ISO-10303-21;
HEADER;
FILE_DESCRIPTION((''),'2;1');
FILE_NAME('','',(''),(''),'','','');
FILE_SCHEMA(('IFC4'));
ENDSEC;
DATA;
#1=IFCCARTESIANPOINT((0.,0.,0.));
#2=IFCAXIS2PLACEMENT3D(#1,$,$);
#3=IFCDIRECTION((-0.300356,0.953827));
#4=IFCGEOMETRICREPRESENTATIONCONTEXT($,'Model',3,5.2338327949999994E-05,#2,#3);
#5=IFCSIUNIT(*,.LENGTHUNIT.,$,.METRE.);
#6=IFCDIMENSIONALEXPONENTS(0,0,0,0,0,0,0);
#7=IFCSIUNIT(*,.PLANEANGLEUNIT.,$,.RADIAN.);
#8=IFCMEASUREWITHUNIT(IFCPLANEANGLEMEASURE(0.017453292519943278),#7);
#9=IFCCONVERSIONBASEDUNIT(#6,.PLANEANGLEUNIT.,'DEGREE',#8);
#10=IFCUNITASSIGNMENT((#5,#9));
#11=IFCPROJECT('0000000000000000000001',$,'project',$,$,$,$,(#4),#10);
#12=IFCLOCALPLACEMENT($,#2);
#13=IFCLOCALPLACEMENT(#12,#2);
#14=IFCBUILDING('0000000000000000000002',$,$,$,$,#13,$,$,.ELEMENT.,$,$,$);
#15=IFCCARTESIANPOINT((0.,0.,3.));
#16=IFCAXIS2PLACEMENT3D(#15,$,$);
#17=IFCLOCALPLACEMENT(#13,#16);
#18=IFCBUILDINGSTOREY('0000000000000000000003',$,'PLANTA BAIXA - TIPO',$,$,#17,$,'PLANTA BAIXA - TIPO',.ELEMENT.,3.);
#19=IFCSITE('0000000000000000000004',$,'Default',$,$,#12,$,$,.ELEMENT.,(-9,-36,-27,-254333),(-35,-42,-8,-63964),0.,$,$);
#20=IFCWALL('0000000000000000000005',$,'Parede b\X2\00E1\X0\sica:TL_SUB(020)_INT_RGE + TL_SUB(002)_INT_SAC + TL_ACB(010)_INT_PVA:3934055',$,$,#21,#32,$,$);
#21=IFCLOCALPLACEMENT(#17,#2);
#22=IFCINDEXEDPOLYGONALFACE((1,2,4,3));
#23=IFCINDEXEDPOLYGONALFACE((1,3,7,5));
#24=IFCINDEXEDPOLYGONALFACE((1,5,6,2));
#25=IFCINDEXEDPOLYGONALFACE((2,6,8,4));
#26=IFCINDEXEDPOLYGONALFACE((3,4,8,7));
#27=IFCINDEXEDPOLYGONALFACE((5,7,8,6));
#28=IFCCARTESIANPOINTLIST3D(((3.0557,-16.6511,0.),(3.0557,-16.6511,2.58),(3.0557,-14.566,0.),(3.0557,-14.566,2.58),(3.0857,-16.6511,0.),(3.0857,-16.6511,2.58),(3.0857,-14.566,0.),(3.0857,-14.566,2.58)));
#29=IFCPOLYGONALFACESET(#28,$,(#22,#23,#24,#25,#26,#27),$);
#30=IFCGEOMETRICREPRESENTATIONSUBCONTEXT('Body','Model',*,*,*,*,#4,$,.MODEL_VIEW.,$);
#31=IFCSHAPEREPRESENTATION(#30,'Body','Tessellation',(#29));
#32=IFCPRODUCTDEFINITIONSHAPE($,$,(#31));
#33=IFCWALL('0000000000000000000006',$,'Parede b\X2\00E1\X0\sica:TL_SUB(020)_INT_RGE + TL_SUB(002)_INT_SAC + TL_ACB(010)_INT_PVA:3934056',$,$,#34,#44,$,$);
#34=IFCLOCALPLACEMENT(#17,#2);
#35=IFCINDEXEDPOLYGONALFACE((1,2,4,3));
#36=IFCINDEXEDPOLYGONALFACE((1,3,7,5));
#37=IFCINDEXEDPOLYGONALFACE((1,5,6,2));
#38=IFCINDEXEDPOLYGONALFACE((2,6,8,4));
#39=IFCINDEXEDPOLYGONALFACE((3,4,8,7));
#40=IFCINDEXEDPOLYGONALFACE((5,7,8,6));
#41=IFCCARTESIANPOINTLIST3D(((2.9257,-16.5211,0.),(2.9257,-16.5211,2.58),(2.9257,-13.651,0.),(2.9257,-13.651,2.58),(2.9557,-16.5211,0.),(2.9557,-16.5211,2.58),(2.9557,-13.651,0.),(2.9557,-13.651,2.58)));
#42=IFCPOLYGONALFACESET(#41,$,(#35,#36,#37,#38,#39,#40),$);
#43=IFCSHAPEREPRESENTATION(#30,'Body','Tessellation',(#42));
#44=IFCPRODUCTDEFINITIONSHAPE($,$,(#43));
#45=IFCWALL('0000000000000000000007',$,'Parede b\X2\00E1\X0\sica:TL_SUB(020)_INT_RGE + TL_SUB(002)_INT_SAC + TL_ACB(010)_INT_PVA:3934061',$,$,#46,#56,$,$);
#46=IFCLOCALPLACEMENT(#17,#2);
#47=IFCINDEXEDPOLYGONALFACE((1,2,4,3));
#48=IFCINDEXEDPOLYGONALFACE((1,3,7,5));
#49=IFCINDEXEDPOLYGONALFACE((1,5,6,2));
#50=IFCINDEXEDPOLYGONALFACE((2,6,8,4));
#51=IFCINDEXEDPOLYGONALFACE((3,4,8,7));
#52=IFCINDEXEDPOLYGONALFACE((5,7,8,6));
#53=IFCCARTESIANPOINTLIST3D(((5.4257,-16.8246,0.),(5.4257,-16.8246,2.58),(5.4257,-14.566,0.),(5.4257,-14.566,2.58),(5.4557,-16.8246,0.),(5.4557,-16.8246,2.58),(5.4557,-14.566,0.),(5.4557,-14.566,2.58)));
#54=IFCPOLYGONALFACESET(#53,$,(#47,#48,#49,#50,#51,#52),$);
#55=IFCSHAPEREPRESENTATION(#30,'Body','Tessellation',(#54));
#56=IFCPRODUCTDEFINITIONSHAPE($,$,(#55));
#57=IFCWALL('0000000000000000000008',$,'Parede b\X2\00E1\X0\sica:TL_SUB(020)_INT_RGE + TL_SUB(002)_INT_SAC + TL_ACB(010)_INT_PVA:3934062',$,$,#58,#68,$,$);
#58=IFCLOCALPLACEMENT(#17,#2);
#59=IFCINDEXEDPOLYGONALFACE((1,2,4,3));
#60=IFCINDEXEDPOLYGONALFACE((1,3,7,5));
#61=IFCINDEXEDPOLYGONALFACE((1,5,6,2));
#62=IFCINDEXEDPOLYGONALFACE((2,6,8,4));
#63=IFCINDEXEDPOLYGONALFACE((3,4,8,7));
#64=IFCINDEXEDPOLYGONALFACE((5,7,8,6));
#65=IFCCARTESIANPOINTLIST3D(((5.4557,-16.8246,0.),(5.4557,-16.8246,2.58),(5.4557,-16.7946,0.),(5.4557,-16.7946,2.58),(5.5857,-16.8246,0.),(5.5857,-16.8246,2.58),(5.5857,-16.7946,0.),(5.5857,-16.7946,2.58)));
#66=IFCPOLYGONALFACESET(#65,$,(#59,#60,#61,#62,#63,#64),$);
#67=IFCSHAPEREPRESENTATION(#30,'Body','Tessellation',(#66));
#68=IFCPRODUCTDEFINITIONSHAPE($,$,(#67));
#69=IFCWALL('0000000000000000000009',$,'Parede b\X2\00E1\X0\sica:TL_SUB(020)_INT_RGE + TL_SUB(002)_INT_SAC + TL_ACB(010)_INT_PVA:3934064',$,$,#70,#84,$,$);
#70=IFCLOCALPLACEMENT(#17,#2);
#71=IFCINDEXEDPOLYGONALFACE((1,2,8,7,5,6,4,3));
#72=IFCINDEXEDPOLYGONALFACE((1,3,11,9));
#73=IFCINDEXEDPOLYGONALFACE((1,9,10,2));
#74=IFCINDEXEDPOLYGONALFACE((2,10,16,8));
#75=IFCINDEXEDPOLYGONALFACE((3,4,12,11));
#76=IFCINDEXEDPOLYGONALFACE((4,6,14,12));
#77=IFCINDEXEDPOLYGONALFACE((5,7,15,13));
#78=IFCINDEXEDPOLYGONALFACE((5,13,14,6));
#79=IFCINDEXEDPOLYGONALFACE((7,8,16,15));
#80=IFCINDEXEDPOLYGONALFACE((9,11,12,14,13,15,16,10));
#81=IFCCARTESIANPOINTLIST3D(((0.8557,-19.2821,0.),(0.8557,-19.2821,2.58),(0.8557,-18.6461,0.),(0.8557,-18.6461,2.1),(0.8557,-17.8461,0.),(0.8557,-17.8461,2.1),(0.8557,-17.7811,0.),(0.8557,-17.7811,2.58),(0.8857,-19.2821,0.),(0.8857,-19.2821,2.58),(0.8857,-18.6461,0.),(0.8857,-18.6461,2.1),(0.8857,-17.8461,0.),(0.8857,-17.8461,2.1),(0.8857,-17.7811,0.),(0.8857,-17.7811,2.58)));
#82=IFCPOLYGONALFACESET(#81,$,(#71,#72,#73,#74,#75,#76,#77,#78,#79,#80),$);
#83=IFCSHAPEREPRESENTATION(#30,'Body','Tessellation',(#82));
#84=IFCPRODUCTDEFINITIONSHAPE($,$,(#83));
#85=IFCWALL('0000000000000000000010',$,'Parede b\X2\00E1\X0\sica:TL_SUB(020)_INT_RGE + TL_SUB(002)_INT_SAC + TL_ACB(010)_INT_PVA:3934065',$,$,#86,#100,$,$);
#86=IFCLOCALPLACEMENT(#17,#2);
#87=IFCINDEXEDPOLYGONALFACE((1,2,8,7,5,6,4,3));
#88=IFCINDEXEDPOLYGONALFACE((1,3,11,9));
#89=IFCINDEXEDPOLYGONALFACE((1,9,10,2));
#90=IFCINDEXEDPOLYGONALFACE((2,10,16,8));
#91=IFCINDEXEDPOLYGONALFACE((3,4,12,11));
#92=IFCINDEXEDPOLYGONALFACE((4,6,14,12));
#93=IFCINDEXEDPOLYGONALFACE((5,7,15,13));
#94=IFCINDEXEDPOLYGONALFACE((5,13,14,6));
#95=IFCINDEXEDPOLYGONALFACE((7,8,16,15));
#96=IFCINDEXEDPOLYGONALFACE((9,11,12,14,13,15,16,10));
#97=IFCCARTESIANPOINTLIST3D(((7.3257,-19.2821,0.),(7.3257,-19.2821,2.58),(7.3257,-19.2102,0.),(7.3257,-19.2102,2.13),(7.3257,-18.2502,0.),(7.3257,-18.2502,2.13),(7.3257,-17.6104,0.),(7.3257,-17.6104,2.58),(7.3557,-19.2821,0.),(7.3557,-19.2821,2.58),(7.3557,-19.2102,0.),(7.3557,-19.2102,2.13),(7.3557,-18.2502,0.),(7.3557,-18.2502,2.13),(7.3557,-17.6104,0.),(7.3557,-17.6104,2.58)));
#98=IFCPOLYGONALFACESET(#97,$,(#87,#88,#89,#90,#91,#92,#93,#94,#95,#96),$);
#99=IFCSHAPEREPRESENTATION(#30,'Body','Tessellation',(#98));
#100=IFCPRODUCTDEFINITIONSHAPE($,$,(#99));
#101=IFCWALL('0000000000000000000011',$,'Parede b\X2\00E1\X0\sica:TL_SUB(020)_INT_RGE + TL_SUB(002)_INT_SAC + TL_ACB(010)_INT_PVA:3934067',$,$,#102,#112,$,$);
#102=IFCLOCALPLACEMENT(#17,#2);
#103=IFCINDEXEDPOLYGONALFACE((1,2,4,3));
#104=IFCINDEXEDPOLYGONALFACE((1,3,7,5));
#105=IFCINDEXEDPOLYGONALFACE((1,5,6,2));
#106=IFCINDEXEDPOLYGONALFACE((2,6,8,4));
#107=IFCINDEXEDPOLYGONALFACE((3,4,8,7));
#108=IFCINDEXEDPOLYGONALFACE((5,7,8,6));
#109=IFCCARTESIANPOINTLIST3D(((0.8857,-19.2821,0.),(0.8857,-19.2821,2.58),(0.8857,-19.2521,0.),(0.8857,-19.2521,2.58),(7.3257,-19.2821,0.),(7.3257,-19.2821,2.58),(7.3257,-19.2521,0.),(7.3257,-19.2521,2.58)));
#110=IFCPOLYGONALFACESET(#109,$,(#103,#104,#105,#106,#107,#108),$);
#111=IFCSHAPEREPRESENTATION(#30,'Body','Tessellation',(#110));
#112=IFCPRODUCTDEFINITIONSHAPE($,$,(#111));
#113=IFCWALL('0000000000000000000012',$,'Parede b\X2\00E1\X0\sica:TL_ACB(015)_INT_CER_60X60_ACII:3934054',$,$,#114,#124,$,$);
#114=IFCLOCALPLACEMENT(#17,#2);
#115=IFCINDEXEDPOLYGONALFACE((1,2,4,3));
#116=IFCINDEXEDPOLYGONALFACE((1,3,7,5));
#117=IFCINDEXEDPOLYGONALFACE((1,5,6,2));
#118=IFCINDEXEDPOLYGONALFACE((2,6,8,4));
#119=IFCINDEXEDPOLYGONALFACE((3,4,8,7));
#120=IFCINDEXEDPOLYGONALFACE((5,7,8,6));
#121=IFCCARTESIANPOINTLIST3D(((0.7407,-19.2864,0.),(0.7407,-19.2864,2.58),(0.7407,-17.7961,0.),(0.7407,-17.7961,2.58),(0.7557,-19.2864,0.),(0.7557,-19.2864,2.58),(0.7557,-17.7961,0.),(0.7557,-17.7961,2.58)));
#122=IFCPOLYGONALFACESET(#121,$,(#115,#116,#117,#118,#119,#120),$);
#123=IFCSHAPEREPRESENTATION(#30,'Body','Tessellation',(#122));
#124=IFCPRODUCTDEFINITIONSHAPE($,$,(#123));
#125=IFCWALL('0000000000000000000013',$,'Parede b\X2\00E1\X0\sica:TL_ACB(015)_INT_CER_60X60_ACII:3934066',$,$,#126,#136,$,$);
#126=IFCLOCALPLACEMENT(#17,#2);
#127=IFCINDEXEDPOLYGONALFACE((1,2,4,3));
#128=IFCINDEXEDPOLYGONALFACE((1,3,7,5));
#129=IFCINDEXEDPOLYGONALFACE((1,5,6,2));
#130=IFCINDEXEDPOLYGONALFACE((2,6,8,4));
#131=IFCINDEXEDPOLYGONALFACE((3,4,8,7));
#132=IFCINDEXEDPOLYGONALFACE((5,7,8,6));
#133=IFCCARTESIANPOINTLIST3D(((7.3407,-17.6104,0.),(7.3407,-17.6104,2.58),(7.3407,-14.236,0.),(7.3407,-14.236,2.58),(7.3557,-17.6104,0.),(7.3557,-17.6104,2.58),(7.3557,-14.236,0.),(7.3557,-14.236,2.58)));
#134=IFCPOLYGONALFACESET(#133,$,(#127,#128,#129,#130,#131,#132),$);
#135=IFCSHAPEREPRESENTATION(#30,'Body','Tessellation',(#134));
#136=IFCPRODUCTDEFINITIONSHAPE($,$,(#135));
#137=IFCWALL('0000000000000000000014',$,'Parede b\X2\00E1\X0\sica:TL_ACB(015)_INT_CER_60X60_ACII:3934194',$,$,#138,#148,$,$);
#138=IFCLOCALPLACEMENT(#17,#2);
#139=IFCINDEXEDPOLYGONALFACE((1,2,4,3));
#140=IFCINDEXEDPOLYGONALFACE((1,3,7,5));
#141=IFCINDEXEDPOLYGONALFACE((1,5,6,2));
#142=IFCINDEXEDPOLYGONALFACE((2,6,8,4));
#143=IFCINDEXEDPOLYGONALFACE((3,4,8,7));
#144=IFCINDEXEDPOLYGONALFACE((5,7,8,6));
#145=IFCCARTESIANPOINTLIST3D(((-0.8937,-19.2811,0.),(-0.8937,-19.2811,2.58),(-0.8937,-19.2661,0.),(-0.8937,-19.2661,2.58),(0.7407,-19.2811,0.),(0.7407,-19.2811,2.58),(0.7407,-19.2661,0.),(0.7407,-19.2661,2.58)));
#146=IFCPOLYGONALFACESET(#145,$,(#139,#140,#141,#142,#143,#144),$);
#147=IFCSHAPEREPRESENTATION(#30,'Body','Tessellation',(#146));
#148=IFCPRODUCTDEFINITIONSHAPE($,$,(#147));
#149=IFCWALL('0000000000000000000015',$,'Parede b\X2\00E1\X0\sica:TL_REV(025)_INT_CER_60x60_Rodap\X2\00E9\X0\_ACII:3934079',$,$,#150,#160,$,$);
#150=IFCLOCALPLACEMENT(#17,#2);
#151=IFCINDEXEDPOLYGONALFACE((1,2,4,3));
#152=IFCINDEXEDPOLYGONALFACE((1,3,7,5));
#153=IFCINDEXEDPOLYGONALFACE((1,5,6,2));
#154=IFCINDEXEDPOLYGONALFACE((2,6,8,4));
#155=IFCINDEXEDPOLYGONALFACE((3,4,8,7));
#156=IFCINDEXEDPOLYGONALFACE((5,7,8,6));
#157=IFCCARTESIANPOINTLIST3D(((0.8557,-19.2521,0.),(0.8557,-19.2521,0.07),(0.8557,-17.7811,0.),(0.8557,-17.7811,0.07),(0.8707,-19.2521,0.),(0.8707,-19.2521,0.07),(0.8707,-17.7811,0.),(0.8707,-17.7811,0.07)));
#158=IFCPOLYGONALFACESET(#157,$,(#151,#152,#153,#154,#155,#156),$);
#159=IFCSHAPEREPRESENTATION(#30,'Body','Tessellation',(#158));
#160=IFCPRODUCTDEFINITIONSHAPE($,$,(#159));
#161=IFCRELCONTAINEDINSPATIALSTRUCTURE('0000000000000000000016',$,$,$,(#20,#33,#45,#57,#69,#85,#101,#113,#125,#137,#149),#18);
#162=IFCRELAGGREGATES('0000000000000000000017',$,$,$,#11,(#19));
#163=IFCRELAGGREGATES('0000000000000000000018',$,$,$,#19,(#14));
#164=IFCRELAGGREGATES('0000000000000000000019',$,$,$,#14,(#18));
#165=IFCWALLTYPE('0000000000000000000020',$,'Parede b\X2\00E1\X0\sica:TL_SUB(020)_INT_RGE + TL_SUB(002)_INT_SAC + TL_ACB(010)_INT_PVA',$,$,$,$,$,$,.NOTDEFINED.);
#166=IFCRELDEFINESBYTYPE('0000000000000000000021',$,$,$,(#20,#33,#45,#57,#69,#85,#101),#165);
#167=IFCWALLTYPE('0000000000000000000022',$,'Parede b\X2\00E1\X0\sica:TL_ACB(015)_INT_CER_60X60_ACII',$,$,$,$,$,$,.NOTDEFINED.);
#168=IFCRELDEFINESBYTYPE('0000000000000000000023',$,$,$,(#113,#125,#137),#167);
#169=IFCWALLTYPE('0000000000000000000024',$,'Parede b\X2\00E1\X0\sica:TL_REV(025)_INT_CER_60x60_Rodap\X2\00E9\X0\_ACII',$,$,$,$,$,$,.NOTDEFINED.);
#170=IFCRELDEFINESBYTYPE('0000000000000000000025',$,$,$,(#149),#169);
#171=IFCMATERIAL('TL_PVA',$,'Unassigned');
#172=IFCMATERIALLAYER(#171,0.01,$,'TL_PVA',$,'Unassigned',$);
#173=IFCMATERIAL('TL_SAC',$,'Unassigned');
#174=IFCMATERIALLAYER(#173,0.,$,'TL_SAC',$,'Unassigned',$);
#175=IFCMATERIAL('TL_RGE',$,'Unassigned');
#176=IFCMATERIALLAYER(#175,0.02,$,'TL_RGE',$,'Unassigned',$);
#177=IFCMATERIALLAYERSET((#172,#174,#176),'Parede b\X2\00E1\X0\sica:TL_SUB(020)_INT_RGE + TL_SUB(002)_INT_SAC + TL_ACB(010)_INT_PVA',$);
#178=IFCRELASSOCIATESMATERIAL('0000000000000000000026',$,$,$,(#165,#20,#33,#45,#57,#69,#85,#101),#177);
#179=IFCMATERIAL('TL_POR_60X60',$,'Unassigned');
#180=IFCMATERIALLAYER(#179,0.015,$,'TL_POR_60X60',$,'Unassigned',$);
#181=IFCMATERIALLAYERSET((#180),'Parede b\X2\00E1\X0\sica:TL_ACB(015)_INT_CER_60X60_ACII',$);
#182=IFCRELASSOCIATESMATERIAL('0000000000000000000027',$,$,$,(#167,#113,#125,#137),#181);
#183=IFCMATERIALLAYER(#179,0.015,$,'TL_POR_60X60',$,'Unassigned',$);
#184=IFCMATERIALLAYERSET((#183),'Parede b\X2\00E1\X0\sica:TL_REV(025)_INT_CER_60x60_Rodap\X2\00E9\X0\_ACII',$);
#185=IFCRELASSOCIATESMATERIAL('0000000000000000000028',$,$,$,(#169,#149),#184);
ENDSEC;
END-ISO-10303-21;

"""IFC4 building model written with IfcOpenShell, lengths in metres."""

from ifc_helpers import new_model, entity, si_unit, converted_unit, direction, frame, frame_2d, origin, place, context, subcontext, project, spatial, rectangle, extrude, material, layer, layer_set, layer_usage, type_object, element, save


model = new_model("IFC4")

# Units and contexts
model_context = context("Model", 3, precision=5.2338327949999994e-05, world=origin(), true_north=direction((-0.300356, 0.953827)))
body_context = subcontext(model_context, "Body", "Model", "MODEL_VIEW")
ifc_project = project(units=[si_unit("LENGTHUNIT", "METRE"), converted_unit("PLANEANGLEUNIT", "DEGREE", entity("IfcPlaneAngleMeasure", 0.017453292519943278), si_unit("PLANEANGLEUNIT", "RADIAN"), dimensions=[0, 0, 0, 0, 0, 0, 0])], contexts=[model_context])

# Site, building, storey
site_placement = place(None, origin())
site = spatial("IfcSite", under=ifc_project, at=site_placement, Name="Default", CompositionType="ELEMENT", RefLatitude=(-9, -36, -27, -254333), RefLongitude=(-35, -42, -8, -63964), RefElevation=0.0)
building_placement = place(site_placement, origin())
building = spatial("IfcBuilding", under=site, at=building_placement, CompositionType="ELEMENT")
storey_placement = place(building_placement, frame((0.0, 0.0, 3.0)))
storey = spatial("IfcBuildingStorey", under=building, at=storey_placement, Name="PLANTA BAIXA - TIPO", LongName="PLANTA BAIXA - TIPO", CompositionType="ELEMENT", Elevation=3.0)

# Shared definitions
ifc_material_1 = material(Name="TL_PVA", Category="Unassigned")
ifc_layer_1 = layer(ifc_material_1, 0.01, Name="TL_PVA", Category="Unassigned")
ifc_material_2 = material(Name="TL_SAC", Category="Unassigned")
ifc_layer_2 = layer(ifc_material_2, 0.0, Name="TL_SAC", Category="Unassigned")
ifc_material_3 = material(Name="TL_RGE", Category="Unassigned")
ifc_layer_3 = layer(ifc_material_3, 0.02, Name="TL_RGE", Category="Unassigned")
ifc_layer_set_1 = layer_set([ifc_layer_1, ifc_layer_2, ifc_layer_3], Name="Parede básica:TL_SUB(020)_INT_RGE + TL_SUB(002)_INT_SAC + TL_ACB(010)_INT_PVA")
wall_type_1 = type_object("IfcWallType", Name="Parede básica:TL_SUB(020)_INT_RGE + TL_SUB(002)_INT_SAC + TL_ACB(010)_INT_PVA", PredefinedType="NOTDEFINED", material=ifc_layer_set_1)

# Walls
ifc_layer_usage_1 = layer_usage(ifc_layer_set_1, "AXIS2", "NEGATIVE", 0.015)
wall_1_placement = place(storey_placement, frame((3.0707, -14.566, 0.0), z_axis=(0.0, 0.0, 1.0), x_axis=(0.0, -1.0, 0.0)))
element("IfcWall", 1, at=wall_1_placement, inside=storey, type_object=wall_type_1, material=ifc_layer_usage_1, Name="Parede básica:TL_SUB(020)_INT_RGE + TL_SUB(002)_INT_SAC + TL_ACB(010)_INT_PVA:3934055", context=body_context, shape_type="SweptSolid", body=[
    extrude(rectangle(XDim=2.0851, YDim=0.03, at=frame_2d((1.0426, 0.0), x_axis=(-1.0, 0.0))), origin(), (0.0, 0.0, 1.0), 2.58),
])
ifc_layer_usage_2 = layer_usage(ifc_layer_set_1, "AXIS2", "NEGATIVE", 0.015)
wall_2_placement = place(storey_placement, frame((2.9407, -16.5211, 0.0), z_axis=(0.0, 0.0, 1.0), x_axis=(0.0, 1.0, 0.0)))
element("IfcWall", 2, at=wall_2_placement, inside=storey, type_object=wall_type_1, material=ifc_layer_usage_2, Name="Parede básica:TL_SUB(020)_INT_RGE + TL_SUB(002)_INT_SAC + TL_ACB(010)_INT_PVA:3934056", context=body_context, shape_type="SweptSolid", body=[
    extrude(rectangle(XDim=2.8701, YDim=0.03, at=frame_2d((1.4351, 0.0), x_axis=(-1.0, 0.0))), origin(), (0.0, 0.0, 1.0), 2.58),
])
ifc_layer_usage_3 = layer_usage(ifc_layer_set_1, "AXIS2", "NEGATIVE", 0.015)
wall_3_placement = place(storey_placement, frame((5.4407, -16.8246, 0.0), z_axis=(0.0, 0.0, 1.0), x_axis=(0.0, 1.0, 0.0)))
element("IfcWall", 3, at=wall_3_placement, inside=storey, type_object=wall_type_1, material=ifc_layer_usage_3, Name="Parede básica:TL_SUB(020)_INT_RGE + TL_SUB(002)_INT_SAC + TL_ACB(010)_INT_PVA:3934061", context=body_context, shape_type="SweptSolid", body=[
    extrude(rectangle(XDim=2.2587, YDim=0.03, at=frame_2d((1.1293, 0.0), x_axis=(-1.0, 0.0))), origin(), (0.0, 0.0, 1.0), 2.58),
])
ifc_layer_usage_4 = layer_usage(ifc_layer_set_1, "AXIS2", "NEGATIVE", 0.015)
wall_4_placement = place(storey_placement, frame((5.5857, -16.8096, 0.0), z_axis=(0.0, 0.0, 1.0), x_axis=(-1.0, 0.0, 0.0)))
element("IfcWall", 4, at=wall_4_placement, inside=storey, type_object=wall_type_1, material=ifc_layer_usage_4, Name="Parede básica:TL_SUB(020)_INT_RGE + TL_SUB(002)_INT_SAC + TL_ACB(010)_INT_PVA:3934062", context=body_context, shape_type="SweptSolid", body=[
    extrude(rectangle(XDim=0.13, YDim=0.03, at=frame_2d((0.065, 0.0), x_axis=(-1.0, 0.0))), origin(), (0.0, 0.0, 1.0), 2.58),
])

# Walls, openings
ifc_layer_usage_5 = layer_usage(ifc_layer_set_1, "AXIS2", "NEGATIVE", 0.015)
wall_5_placement = place(storey_placement, frame((0.8707, -17.7811, 0.0), z_axis=(0.0, 0.0, 1.0), x_axis=(0.0, -1.0, 0.0)))
wall_5 = element("IfcWall", 5, at=wall_5_placement, inside=storey, type_object=wall_type_1, material=ifc_layer_usage_5, Name="Parede básica:TL_SUB(020)_INT_RGE + TL_SUB(002)_INT_SAC + TL_ACB(010)_INT_PVA:3934064", context=body_context, shape_type="SweptSolid", body=[
    extrude(rectangle(XDim=1.501, YDim=0.03, at=frame_2d((0.7505, 0.0), x_axis=(-1.0, 0.0))), origin(), (0.0, 0.0, 1.0), 2.58),
])
opening_1_placement = place(wall_5_placement, frame((0.865, 0.015, 0.0)))
element("IfcOpeningElement", 6, at=opening_1_placement, cuts=wall_5, PredefinedType="OPENING", context=body_context, shape_type="SweptSolid", body=[
    extrude(rectangle(XDim=2.1, YDim=0.8, at=frame_2d((1.05, 0.4), x_axis=(1.0, 0.0))), frame((0.0, 0.0, 0.0), z_axis=(0.0, -1.0, 0.0), x_axis=(0.0, 0.0, 1.0)), (0.0, 0.0, 1.0), 0.03),
])
ifc_layer_usage_6 = layer_usage(ifc_layer_set_1, "AXIS2", "NEGATIVE", 0.015)
wall_6_placement = place(storey_placement, frame((7.3407, -19.2821, 0.0), z_axis=(0.0, 0.0, 1.0), x_axis=(0.0, 1.0, 0.0)))
wall_6 = element("IfcWall", 7, at=wall_6_placement, inside=storey, type_object=wall_type_1, material=ifc_layer_usage_6, Name="Parede básica:TL_SUB(020)_INT_RGE + TL_SUB(002)_INT_SAC + TL_ACB(010)_INT_PVA:3934065", context=body_context, shape_type="SweptSolid", body=[
    extrude(rectangle(XDim=1.6717, YDim=0.03, at=frame_2d((0.8359, 0.0), x_axis=(-1.0, 0.0))), origin(), (0.0, 0.0, 1.0), 2.58),
])
opening_2_placement = place(wall_6_placement, frame((19.2821, 7.3407, 0.0)))
element("IfcOpeningElement", 8, at=opening_2_placement, cuts=wall_6, PredefinedType="OPENING", context=body_context, shape_type="SweptSolid", body=[
    extrude(rectangle(XDim=2.13, YDim=0.96, at=frame_2d((0.0, 0.0), x_axis=(0.0, 1.0))), frame((-18.7302, -8.8797, 1.065), z_axis=(0.0, 1.0, 0.0), x_axis=(-1.0, 0.0, 0.0)), (0.0, 0.0, 1.0), 3.048),
])

# Walls
ifc_layer_usage_7 = layer_usage(ifc_layer_set_1, "AXIS2", "POSITIVE", -0.015)
wall_7_placement = place(storey_placement, frame((7.3257, -19.2671, 0.0), z_axis=(0.0, 0.0, 1.0), x_axis=(-1.0, 0.0, 0.0)))
element("IfcWall", 9, at=wall_7_placement, inside=storey, type_object=wall_type_1, material=ifc_layer_usage_7, Name="Parede básica:TL_SUB(020)_INT_RGE + TL_SUB(002)_INT_SAC + TL_ACB(010)_INT_PVA:3934067", context=body_context, shape_type="SweptSolid", body=[
    extrude(rectangle(XDim=6.44, YDim=0.03, at=frame_2d((3.22, 0.0), x_axis=(-1.0, 0.0))), origin(), (0.0, 0.0, 1.0), 2.58),
])
ifc_material_4 = material(Name="TL_POR_60X60", Category="Unassigned")
ifc_layer_4 = layer(ifc_material_4, 0.015, Name="TL_POR_60X60", Category="Unassigned")
ifc_layer_set_2 = layer_set([ifc_layer_4], Name="Parede básica:TL_ACB(015)_INT_CER_60X60_ACII")
ifc_layer_usage_8 = layer_usage(ifc_layer_set_2, "AXIS2", "NEGATIVE", 0.0075)
wall_type_2 = type_object("IfcWallType", Name="Parede básica:TL_ACB(015)_INT_CER_60X60_ACII", PredefinedType="NOTDEFINED", material=ifc_layer_set_2)
wall_8_placement = place(storey_placement, frame((0.7482, -19.2864, 0.0), z_axis=(0.0, 0.0, 1.0), x_axis=(0.0, 1.0, 0.0)))
element("IfcWall", 10, at=wall_8_placement, inside=storey, type_object=wall_type_2, material=ifc_layer_usage_8, Name="Parede básica:TL_ACB(015)_INT_CER_60X60_ACII:3934054", context=body_context, shape_type="SweptSolid", body=[
    extrude(rectangle(XDim=1.4902, YDim=0.015, at=frame_2d((0.7451, 0.0), x_axis=(-1.0, 0.0))), origin(), (0.0, 0.0, 1.0), 2.58),
])
ifc_layer_usage_9 = layer_usage(ifc_layer_set_2, "AXIS2", "NEGATIVE", 0.0075)
wall_9_placement = place(storey_placement, frame((7.3482, -17.6104, 0.0), z_axis=(0.0, 0.0, 1.0), x_axis=(0.0, 1.0, 0.0)))
element("IfcWall", 11, at=wall_9_placement, inside=storey, type_object=wall_type_2, material=ifc_layer_usage_9, Name="Parede básica:TL_ACB(015)_INT_CER_60X60_ACII:3934066", context=body_context, shape_type="SweptSolid", body=[
    extrude(rectangle(XDim=3.3744, YDim=0.015, at=frame_2d((1.6872, 0.0), x_axis=(-1.0, 0.0))), origin(), (0.0, 0.0, 1.0), 2.58),
])
ifc_layer_usage_10 = layer_usage(ifc_layer_set_2, "AXIS2", "POSITIVE", -0.0075)
wall_10_placement = place(storey_placement, frame((0.7407, -19.2736, 0.0), z_axis=(0.0, 0.0, 1.0), x_axis=(-1.0, 0.0, 0.0)))
element("IfcWall", 12, at=wall_10_placement, inside=storey, type_object=wall_type_2, material=ifc_layer_usage_10, Name="Parede básica:TL_ACB(015)_INT_CER_60X60_ACII:3934194", context=body_context, shape_type="SweptSolid", body=[
    extrude(rectangle(XDim=1.6345, YDim=0.015, at=frame_2d((0.8172, 0.0), x_axis=(-1.0, 0.0))), origin(), (0.0, 0.0, 1.0), 2.58),
])
ifc_layer_5 = layer(ifc_material_4, 0.015, Name="TL_POR_60X60", Category="Unassigned")
ifc_layer_set_3 = layer_set([ifc_layer_5], Name="Parede básica:TL_REV(025)_INT_CER_60x60_Rodapé_ACII")
ifc_layer_usage_11 = layer_usage(ifc_layer_set_3, "AXIS2", "POSITIVE", -0.0075)
wall_type_3 = type_object("IfcWallType", Name="Parede básica:TL_REV(025)_INT_CER_60x60_Rodapé_ACII", PredefinedType="NOTDEFINED", material=ifc_layer_set_3)
wall_11_placement = place(storey_placement, frame((0.8632, -19.2521, 0.0), z_axis=(0.0, 0.0, 1.0), x_axis=(0.0, 1.0, 0.0)))
element("IfcWall", 13, at=wall_11_placement, inside=storey, type_object=wall_type_3, material=ifc_layer_usage_11, Name="Parede básica:TL_REV(025)_INT_CER_60x60_Rodapé_ACII:3934079", context=body_context, shape_type="SweptSolid", body=[
    extrude(rectangle(XDim=1.471, YDim=0.015, at=frame_2d((0.7355, 0.0), x_axis=(-1.0, 0.0))), origin(), (0.0, 0.0, 1.0), 0.07),
])

save(model, "model.ifc")
